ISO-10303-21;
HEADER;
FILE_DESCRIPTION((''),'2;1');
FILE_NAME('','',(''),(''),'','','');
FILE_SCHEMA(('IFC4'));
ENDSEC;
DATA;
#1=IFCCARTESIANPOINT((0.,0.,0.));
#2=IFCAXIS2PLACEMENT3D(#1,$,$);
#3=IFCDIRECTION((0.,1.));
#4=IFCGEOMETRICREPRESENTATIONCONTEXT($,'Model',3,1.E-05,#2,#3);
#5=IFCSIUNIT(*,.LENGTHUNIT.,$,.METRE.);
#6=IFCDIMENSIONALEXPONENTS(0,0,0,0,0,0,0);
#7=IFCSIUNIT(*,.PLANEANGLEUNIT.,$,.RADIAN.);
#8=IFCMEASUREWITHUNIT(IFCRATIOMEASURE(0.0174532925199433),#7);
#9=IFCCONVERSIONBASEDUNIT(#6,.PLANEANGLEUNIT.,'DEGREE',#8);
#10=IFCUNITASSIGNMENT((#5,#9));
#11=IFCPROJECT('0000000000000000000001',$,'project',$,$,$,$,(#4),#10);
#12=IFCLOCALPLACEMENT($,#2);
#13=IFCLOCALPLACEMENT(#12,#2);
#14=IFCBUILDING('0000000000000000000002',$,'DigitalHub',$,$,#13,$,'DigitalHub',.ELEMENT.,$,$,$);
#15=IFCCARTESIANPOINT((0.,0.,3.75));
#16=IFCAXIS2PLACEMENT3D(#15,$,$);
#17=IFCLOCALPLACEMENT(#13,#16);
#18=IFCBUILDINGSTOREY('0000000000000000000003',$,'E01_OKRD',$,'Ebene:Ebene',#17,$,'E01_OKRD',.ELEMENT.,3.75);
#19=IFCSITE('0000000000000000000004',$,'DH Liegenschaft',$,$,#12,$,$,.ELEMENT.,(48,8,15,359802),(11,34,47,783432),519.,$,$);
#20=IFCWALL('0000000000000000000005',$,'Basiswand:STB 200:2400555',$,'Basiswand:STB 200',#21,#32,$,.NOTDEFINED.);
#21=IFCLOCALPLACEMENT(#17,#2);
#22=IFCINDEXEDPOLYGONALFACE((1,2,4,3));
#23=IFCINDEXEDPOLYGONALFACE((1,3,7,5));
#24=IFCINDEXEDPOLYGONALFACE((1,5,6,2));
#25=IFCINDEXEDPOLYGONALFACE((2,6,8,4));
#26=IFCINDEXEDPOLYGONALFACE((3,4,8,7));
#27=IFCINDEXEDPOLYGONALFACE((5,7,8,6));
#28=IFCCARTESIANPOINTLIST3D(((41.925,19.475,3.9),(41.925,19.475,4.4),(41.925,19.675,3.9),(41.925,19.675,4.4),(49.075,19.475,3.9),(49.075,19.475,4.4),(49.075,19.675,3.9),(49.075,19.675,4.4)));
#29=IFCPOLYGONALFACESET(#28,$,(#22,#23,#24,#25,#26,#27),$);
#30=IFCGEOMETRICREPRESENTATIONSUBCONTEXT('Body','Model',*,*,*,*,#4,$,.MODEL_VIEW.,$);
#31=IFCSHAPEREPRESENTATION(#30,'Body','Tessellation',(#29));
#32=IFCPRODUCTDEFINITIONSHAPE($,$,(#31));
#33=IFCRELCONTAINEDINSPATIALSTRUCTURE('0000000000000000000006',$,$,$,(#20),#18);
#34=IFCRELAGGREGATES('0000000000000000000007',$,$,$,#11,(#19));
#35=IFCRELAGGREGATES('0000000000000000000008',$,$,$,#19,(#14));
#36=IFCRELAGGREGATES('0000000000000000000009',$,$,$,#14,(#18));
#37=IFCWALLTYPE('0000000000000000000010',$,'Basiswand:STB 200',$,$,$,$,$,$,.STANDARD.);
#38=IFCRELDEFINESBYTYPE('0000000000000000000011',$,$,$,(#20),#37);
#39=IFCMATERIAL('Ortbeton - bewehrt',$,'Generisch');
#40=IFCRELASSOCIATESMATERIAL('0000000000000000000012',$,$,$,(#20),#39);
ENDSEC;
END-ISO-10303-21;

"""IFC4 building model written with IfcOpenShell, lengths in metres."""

from ifc_helpers import new_model, entity, si_unit, converted_unit, direction, frame, origin, place, context, subcontext, project, spatial, indexed_curve, outline, extrude, material, type_object, element, save


model = new_model("IFC4")

# Units and contexts
model_context = context("Model", 3, precision=1e-05, world=origin(), true_north=direction((0.0, 1.0)))
body_context = subcontext(model_context, "Body", "Model", "MODEL_VIEW")
ifc_project = project(units=[si_unit("LENGTHUNIT", "METRE"), converted_unit("PLANEANGLEUNIT", "DEGREE", entity("IfcRatioMeasure", 0.0174532925199433), si_unit("PLANEANGLEUNIT", "RADIAN"), dimensions=[0, 0, 0, 0, 0, 0, 0])], contexts=[model_context])

# Site, building, storey
site_placement = place(None, frame((0.0, 0.0, 0.0)))
site = spatial("IfcSite", under=ifc_project, at=site_placement, Name="DH Liegenschaft", CompositionType="ELEMENT", RefLatitude=(48, 8, 15, 359802), RefLongitude=(11, 34, 47, 783432), RefElevation=519.0)
building_placement = place(site_placement, origin())
building = spatial("IfcBuilding", under=site, at=building_placement, Name="DigitalHub", LongName="DigitalHub", CompositionType="ELEMENT")
storey_placement = place(building_placement, frame((0.0, 0.0, 3.75)))
storey = spatial("IfcBuildingStorey", under=building, at=storey_placement, Name="E01_OKRD", ObjectType="Ebene:Ebene", LongName="E01_OKRD", CompositionType="ELEMENT", Elevation=3.75)

# Wall
ifc_material_1 = material(Name="Ortbeton - bewehrt", Category="Generisch")
wall_type = type_object("IfcWallType", Name="Basiswand:STB 200", PredefinedType="STANDARD")
wall_1_placement = place(storey_placement, frame((41.925, 19.575, 3.9)))
element("IfcWall", 1, at=wall_1_placement, inside=storey, type_object=wall_type, material=ifc_material_1, Name="Basiswand:STB 200:2400555", ObjectType="Basiswand:STB 200", PredefinedType="NOTDEFINED", context=body_context, shape_type="SweptSolid", body=[
    extrude(outline(indexed_curve([(7.15, 0.1), (0.0, 0.1), (0.0, -0.1), (7.15, -0.1), (7.15, 0.1)], self_intersect=False)), origin(), (0.0, 0.0, 1.0), 0.5),
])

save(model, "model.ifc")
